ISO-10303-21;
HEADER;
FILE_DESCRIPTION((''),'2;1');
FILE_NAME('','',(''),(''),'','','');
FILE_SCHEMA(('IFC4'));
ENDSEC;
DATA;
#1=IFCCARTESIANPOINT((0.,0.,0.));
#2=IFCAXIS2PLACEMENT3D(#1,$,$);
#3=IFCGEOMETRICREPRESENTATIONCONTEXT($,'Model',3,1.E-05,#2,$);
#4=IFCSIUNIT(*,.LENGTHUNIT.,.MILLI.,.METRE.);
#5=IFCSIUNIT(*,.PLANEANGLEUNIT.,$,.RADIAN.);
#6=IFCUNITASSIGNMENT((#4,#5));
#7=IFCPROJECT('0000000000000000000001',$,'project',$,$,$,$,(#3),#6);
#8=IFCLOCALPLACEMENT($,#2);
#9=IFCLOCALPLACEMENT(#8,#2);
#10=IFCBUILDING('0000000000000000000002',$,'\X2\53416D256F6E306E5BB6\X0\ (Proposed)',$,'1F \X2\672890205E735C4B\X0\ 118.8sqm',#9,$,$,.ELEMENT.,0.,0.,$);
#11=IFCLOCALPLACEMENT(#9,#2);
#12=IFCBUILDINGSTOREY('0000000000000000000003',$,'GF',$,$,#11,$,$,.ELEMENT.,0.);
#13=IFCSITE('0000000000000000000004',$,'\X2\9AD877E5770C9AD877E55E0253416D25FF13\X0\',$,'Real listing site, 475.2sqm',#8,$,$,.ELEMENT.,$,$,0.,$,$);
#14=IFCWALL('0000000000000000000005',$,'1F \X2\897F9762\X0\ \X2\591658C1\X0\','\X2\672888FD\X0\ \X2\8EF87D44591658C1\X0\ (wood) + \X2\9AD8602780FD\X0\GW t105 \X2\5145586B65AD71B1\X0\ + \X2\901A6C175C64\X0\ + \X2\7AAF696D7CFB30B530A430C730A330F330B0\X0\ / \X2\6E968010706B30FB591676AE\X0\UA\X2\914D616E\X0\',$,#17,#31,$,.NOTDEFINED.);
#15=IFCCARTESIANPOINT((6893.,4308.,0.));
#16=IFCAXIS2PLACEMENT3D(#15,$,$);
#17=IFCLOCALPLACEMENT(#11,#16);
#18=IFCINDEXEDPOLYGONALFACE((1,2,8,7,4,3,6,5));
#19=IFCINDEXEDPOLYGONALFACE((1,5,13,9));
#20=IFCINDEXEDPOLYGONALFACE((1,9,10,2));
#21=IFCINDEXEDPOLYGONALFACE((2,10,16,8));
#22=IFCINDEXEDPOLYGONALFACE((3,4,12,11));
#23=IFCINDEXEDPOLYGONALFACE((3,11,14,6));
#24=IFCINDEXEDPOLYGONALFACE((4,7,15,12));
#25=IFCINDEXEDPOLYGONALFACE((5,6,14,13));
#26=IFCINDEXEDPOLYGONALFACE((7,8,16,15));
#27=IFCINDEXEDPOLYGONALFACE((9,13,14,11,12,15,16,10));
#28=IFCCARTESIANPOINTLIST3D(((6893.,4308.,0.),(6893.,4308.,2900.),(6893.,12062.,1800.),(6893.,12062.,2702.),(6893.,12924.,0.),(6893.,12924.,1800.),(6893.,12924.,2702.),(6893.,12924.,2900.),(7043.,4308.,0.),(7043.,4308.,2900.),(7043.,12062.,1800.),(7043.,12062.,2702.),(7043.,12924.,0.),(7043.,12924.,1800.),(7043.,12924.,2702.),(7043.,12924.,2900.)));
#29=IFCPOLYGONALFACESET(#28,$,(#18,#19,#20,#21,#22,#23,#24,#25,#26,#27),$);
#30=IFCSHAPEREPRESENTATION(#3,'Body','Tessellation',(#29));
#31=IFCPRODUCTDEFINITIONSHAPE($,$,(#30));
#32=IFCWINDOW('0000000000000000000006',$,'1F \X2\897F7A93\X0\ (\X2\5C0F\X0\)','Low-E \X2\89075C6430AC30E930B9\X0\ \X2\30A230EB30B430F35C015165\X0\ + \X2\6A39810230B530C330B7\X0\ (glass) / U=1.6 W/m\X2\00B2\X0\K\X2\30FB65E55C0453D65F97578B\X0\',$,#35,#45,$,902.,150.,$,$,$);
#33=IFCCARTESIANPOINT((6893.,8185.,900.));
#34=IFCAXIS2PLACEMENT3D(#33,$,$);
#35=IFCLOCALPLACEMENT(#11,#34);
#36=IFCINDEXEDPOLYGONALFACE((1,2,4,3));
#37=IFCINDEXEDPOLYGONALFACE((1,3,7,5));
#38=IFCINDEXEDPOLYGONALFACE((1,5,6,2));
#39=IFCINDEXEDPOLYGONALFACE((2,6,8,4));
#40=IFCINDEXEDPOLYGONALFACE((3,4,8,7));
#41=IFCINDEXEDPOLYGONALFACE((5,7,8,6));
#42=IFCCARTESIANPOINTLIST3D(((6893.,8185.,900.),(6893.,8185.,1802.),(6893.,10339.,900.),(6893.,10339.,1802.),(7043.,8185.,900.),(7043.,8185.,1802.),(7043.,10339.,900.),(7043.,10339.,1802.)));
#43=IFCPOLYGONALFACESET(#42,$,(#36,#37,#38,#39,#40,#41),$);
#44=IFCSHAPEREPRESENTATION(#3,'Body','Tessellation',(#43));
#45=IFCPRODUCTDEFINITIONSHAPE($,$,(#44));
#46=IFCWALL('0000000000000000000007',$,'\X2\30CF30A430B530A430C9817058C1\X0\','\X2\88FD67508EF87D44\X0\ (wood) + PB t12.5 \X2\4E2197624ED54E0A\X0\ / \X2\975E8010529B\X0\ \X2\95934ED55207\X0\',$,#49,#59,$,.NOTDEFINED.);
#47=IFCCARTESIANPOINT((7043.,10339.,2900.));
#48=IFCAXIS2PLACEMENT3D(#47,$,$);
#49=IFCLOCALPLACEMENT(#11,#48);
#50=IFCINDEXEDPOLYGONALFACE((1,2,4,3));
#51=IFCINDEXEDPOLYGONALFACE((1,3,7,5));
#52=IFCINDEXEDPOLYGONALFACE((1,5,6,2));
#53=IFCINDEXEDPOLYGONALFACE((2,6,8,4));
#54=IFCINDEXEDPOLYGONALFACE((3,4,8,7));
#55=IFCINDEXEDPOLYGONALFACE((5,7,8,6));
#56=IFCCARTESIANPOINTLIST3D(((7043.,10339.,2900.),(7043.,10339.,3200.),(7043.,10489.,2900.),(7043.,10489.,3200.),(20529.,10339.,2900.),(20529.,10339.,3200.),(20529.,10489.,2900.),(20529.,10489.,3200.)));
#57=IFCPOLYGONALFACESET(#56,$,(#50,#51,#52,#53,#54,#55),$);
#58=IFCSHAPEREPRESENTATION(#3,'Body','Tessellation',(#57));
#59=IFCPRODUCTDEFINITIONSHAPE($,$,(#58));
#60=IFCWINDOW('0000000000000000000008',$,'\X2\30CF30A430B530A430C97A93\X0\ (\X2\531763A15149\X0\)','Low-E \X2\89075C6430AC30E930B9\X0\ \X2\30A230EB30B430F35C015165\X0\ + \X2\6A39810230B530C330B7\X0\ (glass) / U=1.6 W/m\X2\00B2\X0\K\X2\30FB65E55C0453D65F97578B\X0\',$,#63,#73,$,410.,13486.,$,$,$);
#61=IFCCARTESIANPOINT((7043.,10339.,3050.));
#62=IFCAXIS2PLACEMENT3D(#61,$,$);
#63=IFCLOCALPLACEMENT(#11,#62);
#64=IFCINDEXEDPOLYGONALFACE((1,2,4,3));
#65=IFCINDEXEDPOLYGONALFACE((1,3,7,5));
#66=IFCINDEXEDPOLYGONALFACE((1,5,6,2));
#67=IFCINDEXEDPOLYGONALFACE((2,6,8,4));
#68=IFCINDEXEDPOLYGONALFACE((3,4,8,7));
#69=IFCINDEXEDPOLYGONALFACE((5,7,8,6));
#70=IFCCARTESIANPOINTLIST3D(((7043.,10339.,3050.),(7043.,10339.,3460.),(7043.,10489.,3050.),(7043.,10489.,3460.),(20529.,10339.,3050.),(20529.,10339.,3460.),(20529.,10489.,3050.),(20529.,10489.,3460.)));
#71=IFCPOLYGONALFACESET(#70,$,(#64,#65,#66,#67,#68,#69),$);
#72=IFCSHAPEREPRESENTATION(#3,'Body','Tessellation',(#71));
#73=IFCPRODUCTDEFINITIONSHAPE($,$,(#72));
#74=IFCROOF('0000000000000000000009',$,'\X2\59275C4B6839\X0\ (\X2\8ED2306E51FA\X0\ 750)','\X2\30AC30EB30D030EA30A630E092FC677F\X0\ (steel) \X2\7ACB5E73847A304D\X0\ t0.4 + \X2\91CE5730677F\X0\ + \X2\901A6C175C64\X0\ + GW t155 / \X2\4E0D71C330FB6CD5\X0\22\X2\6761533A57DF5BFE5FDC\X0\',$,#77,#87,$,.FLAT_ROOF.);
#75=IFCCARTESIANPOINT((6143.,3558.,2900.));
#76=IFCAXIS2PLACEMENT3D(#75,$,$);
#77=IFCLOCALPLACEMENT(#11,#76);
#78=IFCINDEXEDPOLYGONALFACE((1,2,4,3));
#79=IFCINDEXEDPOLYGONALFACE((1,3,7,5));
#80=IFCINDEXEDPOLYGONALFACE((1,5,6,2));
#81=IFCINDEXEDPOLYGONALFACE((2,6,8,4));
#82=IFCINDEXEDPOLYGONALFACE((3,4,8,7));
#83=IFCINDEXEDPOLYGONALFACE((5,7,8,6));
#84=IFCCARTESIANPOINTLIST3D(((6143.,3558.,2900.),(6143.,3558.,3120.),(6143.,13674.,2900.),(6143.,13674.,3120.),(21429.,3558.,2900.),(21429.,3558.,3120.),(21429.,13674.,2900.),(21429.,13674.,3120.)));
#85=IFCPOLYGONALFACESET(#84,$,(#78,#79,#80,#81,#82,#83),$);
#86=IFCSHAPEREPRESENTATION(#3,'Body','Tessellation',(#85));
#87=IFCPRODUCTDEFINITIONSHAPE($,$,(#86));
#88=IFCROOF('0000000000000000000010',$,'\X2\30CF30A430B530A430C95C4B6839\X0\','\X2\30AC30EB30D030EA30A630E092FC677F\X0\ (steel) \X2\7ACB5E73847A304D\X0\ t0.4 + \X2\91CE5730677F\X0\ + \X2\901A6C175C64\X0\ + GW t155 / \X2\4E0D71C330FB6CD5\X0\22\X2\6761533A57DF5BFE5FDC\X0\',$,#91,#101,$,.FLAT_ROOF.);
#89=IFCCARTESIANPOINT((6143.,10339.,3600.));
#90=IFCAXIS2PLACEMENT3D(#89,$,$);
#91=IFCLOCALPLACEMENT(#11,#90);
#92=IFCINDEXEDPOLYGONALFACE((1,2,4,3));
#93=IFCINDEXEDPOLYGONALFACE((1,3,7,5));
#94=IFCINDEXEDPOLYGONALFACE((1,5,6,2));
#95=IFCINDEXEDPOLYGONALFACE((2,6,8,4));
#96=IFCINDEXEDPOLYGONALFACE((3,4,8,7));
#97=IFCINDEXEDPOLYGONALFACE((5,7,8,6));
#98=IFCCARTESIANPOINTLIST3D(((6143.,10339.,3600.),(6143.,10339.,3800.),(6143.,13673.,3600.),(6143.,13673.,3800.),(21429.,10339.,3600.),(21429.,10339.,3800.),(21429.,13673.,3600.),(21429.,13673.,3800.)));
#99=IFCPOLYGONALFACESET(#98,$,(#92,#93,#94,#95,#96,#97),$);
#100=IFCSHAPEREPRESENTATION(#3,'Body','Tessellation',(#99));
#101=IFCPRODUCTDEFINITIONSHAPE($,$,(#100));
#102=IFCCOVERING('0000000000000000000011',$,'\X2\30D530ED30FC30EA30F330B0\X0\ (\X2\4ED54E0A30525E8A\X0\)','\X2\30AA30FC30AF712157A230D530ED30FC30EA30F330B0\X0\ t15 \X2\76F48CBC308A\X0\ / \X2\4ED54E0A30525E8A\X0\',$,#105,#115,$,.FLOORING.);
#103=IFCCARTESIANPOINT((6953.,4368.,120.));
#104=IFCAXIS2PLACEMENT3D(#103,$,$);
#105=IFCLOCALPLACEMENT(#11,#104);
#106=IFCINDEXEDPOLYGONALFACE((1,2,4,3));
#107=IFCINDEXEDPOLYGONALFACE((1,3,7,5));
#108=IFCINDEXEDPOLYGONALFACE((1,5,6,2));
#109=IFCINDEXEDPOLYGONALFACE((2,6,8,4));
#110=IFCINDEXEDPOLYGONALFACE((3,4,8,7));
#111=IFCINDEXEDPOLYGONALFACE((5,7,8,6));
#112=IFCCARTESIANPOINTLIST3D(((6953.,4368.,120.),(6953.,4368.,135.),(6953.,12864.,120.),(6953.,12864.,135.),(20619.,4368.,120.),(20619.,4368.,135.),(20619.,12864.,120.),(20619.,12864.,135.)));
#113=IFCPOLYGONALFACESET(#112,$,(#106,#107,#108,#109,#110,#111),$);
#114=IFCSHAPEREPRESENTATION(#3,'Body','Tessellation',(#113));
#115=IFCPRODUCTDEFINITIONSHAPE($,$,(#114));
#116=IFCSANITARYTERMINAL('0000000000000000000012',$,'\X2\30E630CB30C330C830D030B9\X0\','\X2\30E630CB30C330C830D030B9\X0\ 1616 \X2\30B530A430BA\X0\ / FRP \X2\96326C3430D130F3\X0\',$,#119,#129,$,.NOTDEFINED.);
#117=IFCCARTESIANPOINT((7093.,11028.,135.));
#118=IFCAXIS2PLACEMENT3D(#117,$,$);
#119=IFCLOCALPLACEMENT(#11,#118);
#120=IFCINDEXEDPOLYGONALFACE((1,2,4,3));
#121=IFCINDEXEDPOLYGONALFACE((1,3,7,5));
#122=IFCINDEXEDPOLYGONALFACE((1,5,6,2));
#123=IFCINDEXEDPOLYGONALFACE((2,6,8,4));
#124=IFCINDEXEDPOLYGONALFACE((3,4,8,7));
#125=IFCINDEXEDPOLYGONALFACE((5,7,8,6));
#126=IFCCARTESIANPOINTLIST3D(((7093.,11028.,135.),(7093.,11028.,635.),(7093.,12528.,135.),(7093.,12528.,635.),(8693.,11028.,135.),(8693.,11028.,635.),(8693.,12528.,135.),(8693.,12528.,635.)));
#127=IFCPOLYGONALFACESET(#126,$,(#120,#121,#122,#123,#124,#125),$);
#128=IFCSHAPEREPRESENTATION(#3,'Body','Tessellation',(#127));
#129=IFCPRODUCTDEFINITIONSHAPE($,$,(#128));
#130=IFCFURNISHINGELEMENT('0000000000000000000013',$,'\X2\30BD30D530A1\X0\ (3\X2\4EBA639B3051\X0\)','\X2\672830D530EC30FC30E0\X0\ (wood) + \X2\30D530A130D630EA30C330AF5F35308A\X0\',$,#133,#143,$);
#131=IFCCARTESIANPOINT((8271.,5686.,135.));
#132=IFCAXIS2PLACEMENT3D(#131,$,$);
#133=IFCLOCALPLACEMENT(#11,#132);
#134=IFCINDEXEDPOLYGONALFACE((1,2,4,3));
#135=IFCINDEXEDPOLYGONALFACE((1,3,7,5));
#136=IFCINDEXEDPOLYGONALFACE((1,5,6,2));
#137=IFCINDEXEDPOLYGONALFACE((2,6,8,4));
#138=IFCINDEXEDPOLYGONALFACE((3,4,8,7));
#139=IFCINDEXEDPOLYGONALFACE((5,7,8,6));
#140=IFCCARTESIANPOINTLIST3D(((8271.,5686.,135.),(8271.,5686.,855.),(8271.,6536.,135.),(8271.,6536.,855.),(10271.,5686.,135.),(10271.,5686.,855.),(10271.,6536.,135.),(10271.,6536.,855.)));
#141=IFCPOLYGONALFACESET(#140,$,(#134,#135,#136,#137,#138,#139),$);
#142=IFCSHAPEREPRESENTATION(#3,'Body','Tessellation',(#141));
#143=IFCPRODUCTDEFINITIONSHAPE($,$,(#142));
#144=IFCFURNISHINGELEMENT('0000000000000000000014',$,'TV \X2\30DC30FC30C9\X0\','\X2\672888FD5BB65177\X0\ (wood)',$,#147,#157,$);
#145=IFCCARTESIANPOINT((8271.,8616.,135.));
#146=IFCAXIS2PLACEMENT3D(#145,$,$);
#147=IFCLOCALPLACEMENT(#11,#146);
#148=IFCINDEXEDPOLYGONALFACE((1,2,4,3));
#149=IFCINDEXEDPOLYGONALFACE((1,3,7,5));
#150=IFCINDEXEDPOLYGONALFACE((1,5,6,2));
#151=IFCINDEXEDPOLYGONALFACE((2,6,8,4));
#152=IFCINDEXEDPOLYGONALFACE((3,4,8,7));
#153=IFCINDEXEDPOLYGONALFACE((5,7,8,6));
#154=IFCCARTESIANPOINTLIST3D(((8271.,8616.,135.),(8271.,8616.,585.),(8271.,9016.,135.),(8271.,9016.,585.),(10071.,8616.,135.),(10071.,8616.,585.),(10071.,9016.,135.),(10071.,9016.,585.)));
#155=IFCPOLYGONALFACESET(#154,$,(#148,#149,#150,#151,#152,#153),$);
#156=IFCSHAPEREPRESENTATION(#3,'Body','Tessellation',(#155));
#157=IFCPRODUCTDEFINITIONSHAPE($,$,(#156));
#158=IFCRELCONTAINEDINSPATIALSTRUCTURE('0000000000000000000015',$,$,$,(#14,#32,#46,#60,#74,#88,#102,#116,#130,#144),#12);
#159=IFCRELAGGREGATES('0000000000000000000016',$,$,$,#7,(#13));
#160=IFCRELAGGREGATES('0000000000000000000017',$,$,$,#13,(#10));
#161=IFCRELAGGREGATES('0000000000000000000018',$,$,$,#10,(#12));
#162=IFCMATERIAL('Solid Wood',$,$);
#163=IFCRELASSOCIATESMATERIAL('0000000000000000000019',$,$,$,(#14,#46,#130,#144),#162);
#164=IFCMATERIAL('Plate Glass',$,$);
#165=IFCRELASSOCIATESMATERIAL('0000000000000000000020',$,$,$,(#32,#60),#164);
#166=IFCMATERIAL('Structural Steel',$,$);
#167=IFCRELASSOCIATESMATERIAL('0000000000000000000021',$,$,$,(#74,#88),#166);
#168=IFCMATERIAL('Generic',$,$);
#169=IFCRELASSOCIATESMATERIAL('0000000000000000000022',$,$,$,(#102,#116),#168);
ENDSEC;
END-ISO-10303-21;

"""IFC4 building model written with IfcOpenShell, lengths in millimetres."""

from ifc_helpers import new_model, si_unit, frame, frame_2d, origin, place, context, project, spatial, rectangle, extrude, material, element, fill, save


model = new_model("IFC4")

# Units and contexts
model_context = context("Model", 3, precision=1e-05, world=origin())
ifc_project = project(units=[si_unit("LENGTHUNIT", "METRE", prefix="MILLI"), si_unit("PLANEANGLEUNIT", "RADIAN")], contexts=[model_context])

# Site, building, storey
site_placement = place(None, origin())
site = spatial("IfcSite", under=ifc_project, at=site_placement, Name="高知県高知市十津３", ObjectType="Real listing site, 475.2sqm", CompositionType="ELEMENT", RefElevation=0.0)
building_placement = place(site_placement, origin())
building = spatial("IfcBuilding", under=site, at=building_placement, Name="十津潮の家 (Proposed)", ObjectType="1F 木造平屋 118.8sqm", CompositionType="ELEMENT", ElevationOfRefHeight=0.0, ElevationOfTerrain=0.0)
storey_placement = place(building_placement, origin())
storey = spatial("IfcBuildingStorey", under=building, at=storey_placement, Name="GF", CompositionType="ELEMENT", Elevation=0.0)

# Shared definitions
ifc_material_1 = material(Name="Solid Wood")

# Shared definitions
ifc_material_2 = material(Name="Plate Glass")

# Wall, opening, window
wall_1_placement = place(storey_placement, frame((6893.0, 4308.0, 0.0)))
wall_1 = element("IfcWall", 1, at=wall_1_placement, inside=storey, material=ifc_material_1, Name="1F 西面 外壁", Description="木製 軸組外壁 (wood) + 高性能GW t105 充填断熱 + 通気層 + 窯業系サイディング / 準耐火・外皮UA配慮", PredefinedType="NOTDEFINED", context=model_context, shape_type="SweptSolid", body=[
    extrude(rectangle(XDim=150.0, YDim=8616.0, at=frame_2d((75.0, 4308.0))), frame((6893.0, 4308.0, 0.0)), (0.0, 0.0, 1.0), 2900.0),
])
opening_1_placement = place(storey_placement, frame((6893.0, 8185.0, 900.0)))
opening_1 = element("IfcOpeningElement", 2, at=opening_1_placement, cuts=wall_1, PredefinedType="NOTDEFINED", context=model_context, shape_type="SweptSolid", body=[
    extrude(rectangle(XDim=150.0, YDim=2154.0, at=frame_2d((75.0, 1077.0))), frame((6893.0, 8185.0, 900.0)), (0.0, 0.0, 1.0), 902.0),
])
window_1_placement = place(storey_placement, frame((6893.0, 8185.0, 900.0)))
window_1 = element("IfcWindow", 3, at=window_1_placement, inside=storey, material=ifc_material_2, Name="1F 西窓 (小)", Description="Low-E 複層ガラス アルゴン封入 + 樹脂サッシ (glass) / U=1.6 W/m²K・日射取得型", OverallHeight=902.0, OverallWidth=150.0, context=model_context, shape_type="SweptSolid", body=[
    extrude(rectangle(XDim=150.0, YDim=2154.0, at=frame_2d((75.0, 1077.0))), frame((6893.0, 8185.0, 900.0)), (0.0, 0.0, 1.0), 902.0),
])
fill(opening_1, window_1)

# Wall, opening, window
wall_2_placement = place(storey_placement, frame((7043.0, 10339.0, 2900.0)))
wall_2 = element("IfcWall", 4, at=wall_2_placement, inside=storey, material=ifc_material_1, Name="ハイサイド腰壁", Description="製材軸組 (wood) + PB t12.5 両面仕上 / 非耐力 間仕切", PredefinedType="NOTDEFINED", context=model_context, shape_type="SweptSolid", body=[
    extrude(rectangle(XDim=13486.0, YDim=150.0, at=frame_2d((6743.0, 75.0))), frame((7043.0, 10339.0, 2900.0)), (0.0, 0.0, 1.0), 700.0),
])
opening_2_placement = place(storey_placement, frame((7043.0, 10339.0, 3050.0)))
opening_2 = element("IfcOpeningElement", 5, at=opening_2_placement, cuts=wall_2, PredefinedType="NOTDEFINED", context=model_context, shape_type="SweptSolid", body=[
    extrude(rectangle(XDim=13486.0, YDim=150.0, at=frame_2d((6743.0, 75.0))), frame((7043.0, 10339.0, 3050.0)), (0.0, 0.0, 1.0), 410.0),
])
window_2_placement = place(storey_placement, frame((7043.0, 10339.0, 3050.0)))
window_2 = element("IfcWindow", 6, at=window_2_placement, inside=storey, material=ifc_material_2, Name="ハイサイド窓 (北採光)", Description="Low-E 複層ガラス アルゴン封入 + 樹脂サッシ (glass) / U=1.6 W/m²K・日射取得型", OverallHeight=410.0, OverallWidth=13486.0, context=model_context, shape_type="SweptSolid", body=[
    extrude(rectangle(XDim=13486.0, YDim=150.0, at=frame_2d((6743.0, 75.0))), frame((7043.0, 10339.0, 3050.0)), (0.0, 0.0, 1.0), 410.0),
])
fill(opening_2, window_2)

# Roofs
ifc_material_3 = material(Name="Structural Steel")
roof_1_placement = place(storey_placement, frame((6143.0, 3558.0, 2900.0)))
element("IfcRoof", 7, at=roof_1_placement, inside=storey, material=ifc_material_3, Name="大屋根 (軒の出 750)", Description="ガルバリウム鋼板 (steel) 立平葺き t0.4 + 野地板 + 通気層 + GW t155 / 不燃・法22条区域対応", PredefinedType="FLAT_ROOF", context=model_context, shape_type="SweptSolid", body=[
    extrude(rectangle(XDim=15286.0, YDim=10116.0, at=frame_2d((7643.0, 5058.0))), frame((6143.0, 3558.0, 2900.0)), (0.0, 0.0, 1.0), 220.0),
])
roof_2_placement = place(storey_placement, frame((6143.0, 10339.0, 3600.0)))
element("IfcRoof", 8, at=roof_2_placement, inside=storey, material=ifc_material_3, Name="ハイサイド屋根", Description="ガルバリウム鋼板 (steel) 立平葺き t0.4 + 野地板 + 通気層 + GW t155 / 不燃・法22条区域対応", PredefinedType="FLAT_ROOF", context=model_context, shape_type="SweptSolid", body=[
    extrude(rectangle(XDim=15286.0, YDim=3334.0, at=frame_2d((7643.0, 1667.0))), frame((6143.0, 10339.0, 3600.0)), (0.0, 0.0, 1.0), 200.0),
])

# Covering
ifc_material_4 = material(Name="Generic")
covering_placement = place(storey_placement, frame((6953.0, 4368.0, 120.0)))
element("IfcCovering", 9, at=covering_placement, inside=storey, material=ifc_material_4, Name="フローリング (仕上げ床)", Description="オーク無垢フローリング t15 直貼り / 仕上げ床", PredefinedType="FLOORING", context=model_context, shape_type="SweptSolid", body=[
    extrude(rectangle(XDim=13666.0, YDim=8496.0, at=frame_2d((6833.0, 4248.0))), frame((6953.0, 4368.0, 120.0)), (0.0, 0.0, 1.0), 15.0),
])

# Sanitary terminal
sanitary_terminal_placement = place(storey_placement, frame((7093.0, 11028.0, 135.0)))
element("IfcSanitaryTerminal", 10, at=sanitary_terminal_placement, inside=storey, material=ifc_material_4, Name="ユニットバス", Description="ユニットバス 1616 サイズ / FRP 防水パン", PredefinedType="NOTDEFINED", context=model_context, shape_type="SweptSolid", body=[
    extrude(rectangle(XDim=1600.0, YDim=1500.0, at=frame_2d((800.0, 750.0))), frame((7093.0, 11028.0, 135.0)), (0.0, 0.0, 1.0), 500.0),
])

# Furnishing elements
furnishing_1_placement = place(storey_placement, frame((8271.0, 5686.0, 135.0)))
element("IfcFurnishingElement", 11, at=furnishing_1_placement, inside=storey, material=ifc_material_1, Name="ソファ (3人掛け)", Description="木フレーム (wood) + ファブリック張り", context=model_context, shape_type="SweptSolid", body=[
    extrude(rectangle(XDim=2000.0, YDim=850.0, at=frame_2d((1000.0, 425.0))), frame((8271.0, 5686.0, 135.0)), (0.0, 0.0, 1.0), 720.0),
])
furnishing_2_placement = place(storey_placement, frame((8271.0, 8616.0, 135.0)))
element("IfcFurnishingElement", 12, at=furnishing_2_placement, inside=storey, material=ifc_material_1, Name="TV ボード", Description="木製家具 (wood)", context=model_context, shape_type="SweptSolid", body=[
    extrude(rectangle(XDim=1800.0, YDim=400.0, at=frame_2d((900.0, 200.0))), frame((8271.0, 8616.0, 135.0)), (0.0, 0.0, 1.0), 450.0),
])

save(model, "model.ifc")
